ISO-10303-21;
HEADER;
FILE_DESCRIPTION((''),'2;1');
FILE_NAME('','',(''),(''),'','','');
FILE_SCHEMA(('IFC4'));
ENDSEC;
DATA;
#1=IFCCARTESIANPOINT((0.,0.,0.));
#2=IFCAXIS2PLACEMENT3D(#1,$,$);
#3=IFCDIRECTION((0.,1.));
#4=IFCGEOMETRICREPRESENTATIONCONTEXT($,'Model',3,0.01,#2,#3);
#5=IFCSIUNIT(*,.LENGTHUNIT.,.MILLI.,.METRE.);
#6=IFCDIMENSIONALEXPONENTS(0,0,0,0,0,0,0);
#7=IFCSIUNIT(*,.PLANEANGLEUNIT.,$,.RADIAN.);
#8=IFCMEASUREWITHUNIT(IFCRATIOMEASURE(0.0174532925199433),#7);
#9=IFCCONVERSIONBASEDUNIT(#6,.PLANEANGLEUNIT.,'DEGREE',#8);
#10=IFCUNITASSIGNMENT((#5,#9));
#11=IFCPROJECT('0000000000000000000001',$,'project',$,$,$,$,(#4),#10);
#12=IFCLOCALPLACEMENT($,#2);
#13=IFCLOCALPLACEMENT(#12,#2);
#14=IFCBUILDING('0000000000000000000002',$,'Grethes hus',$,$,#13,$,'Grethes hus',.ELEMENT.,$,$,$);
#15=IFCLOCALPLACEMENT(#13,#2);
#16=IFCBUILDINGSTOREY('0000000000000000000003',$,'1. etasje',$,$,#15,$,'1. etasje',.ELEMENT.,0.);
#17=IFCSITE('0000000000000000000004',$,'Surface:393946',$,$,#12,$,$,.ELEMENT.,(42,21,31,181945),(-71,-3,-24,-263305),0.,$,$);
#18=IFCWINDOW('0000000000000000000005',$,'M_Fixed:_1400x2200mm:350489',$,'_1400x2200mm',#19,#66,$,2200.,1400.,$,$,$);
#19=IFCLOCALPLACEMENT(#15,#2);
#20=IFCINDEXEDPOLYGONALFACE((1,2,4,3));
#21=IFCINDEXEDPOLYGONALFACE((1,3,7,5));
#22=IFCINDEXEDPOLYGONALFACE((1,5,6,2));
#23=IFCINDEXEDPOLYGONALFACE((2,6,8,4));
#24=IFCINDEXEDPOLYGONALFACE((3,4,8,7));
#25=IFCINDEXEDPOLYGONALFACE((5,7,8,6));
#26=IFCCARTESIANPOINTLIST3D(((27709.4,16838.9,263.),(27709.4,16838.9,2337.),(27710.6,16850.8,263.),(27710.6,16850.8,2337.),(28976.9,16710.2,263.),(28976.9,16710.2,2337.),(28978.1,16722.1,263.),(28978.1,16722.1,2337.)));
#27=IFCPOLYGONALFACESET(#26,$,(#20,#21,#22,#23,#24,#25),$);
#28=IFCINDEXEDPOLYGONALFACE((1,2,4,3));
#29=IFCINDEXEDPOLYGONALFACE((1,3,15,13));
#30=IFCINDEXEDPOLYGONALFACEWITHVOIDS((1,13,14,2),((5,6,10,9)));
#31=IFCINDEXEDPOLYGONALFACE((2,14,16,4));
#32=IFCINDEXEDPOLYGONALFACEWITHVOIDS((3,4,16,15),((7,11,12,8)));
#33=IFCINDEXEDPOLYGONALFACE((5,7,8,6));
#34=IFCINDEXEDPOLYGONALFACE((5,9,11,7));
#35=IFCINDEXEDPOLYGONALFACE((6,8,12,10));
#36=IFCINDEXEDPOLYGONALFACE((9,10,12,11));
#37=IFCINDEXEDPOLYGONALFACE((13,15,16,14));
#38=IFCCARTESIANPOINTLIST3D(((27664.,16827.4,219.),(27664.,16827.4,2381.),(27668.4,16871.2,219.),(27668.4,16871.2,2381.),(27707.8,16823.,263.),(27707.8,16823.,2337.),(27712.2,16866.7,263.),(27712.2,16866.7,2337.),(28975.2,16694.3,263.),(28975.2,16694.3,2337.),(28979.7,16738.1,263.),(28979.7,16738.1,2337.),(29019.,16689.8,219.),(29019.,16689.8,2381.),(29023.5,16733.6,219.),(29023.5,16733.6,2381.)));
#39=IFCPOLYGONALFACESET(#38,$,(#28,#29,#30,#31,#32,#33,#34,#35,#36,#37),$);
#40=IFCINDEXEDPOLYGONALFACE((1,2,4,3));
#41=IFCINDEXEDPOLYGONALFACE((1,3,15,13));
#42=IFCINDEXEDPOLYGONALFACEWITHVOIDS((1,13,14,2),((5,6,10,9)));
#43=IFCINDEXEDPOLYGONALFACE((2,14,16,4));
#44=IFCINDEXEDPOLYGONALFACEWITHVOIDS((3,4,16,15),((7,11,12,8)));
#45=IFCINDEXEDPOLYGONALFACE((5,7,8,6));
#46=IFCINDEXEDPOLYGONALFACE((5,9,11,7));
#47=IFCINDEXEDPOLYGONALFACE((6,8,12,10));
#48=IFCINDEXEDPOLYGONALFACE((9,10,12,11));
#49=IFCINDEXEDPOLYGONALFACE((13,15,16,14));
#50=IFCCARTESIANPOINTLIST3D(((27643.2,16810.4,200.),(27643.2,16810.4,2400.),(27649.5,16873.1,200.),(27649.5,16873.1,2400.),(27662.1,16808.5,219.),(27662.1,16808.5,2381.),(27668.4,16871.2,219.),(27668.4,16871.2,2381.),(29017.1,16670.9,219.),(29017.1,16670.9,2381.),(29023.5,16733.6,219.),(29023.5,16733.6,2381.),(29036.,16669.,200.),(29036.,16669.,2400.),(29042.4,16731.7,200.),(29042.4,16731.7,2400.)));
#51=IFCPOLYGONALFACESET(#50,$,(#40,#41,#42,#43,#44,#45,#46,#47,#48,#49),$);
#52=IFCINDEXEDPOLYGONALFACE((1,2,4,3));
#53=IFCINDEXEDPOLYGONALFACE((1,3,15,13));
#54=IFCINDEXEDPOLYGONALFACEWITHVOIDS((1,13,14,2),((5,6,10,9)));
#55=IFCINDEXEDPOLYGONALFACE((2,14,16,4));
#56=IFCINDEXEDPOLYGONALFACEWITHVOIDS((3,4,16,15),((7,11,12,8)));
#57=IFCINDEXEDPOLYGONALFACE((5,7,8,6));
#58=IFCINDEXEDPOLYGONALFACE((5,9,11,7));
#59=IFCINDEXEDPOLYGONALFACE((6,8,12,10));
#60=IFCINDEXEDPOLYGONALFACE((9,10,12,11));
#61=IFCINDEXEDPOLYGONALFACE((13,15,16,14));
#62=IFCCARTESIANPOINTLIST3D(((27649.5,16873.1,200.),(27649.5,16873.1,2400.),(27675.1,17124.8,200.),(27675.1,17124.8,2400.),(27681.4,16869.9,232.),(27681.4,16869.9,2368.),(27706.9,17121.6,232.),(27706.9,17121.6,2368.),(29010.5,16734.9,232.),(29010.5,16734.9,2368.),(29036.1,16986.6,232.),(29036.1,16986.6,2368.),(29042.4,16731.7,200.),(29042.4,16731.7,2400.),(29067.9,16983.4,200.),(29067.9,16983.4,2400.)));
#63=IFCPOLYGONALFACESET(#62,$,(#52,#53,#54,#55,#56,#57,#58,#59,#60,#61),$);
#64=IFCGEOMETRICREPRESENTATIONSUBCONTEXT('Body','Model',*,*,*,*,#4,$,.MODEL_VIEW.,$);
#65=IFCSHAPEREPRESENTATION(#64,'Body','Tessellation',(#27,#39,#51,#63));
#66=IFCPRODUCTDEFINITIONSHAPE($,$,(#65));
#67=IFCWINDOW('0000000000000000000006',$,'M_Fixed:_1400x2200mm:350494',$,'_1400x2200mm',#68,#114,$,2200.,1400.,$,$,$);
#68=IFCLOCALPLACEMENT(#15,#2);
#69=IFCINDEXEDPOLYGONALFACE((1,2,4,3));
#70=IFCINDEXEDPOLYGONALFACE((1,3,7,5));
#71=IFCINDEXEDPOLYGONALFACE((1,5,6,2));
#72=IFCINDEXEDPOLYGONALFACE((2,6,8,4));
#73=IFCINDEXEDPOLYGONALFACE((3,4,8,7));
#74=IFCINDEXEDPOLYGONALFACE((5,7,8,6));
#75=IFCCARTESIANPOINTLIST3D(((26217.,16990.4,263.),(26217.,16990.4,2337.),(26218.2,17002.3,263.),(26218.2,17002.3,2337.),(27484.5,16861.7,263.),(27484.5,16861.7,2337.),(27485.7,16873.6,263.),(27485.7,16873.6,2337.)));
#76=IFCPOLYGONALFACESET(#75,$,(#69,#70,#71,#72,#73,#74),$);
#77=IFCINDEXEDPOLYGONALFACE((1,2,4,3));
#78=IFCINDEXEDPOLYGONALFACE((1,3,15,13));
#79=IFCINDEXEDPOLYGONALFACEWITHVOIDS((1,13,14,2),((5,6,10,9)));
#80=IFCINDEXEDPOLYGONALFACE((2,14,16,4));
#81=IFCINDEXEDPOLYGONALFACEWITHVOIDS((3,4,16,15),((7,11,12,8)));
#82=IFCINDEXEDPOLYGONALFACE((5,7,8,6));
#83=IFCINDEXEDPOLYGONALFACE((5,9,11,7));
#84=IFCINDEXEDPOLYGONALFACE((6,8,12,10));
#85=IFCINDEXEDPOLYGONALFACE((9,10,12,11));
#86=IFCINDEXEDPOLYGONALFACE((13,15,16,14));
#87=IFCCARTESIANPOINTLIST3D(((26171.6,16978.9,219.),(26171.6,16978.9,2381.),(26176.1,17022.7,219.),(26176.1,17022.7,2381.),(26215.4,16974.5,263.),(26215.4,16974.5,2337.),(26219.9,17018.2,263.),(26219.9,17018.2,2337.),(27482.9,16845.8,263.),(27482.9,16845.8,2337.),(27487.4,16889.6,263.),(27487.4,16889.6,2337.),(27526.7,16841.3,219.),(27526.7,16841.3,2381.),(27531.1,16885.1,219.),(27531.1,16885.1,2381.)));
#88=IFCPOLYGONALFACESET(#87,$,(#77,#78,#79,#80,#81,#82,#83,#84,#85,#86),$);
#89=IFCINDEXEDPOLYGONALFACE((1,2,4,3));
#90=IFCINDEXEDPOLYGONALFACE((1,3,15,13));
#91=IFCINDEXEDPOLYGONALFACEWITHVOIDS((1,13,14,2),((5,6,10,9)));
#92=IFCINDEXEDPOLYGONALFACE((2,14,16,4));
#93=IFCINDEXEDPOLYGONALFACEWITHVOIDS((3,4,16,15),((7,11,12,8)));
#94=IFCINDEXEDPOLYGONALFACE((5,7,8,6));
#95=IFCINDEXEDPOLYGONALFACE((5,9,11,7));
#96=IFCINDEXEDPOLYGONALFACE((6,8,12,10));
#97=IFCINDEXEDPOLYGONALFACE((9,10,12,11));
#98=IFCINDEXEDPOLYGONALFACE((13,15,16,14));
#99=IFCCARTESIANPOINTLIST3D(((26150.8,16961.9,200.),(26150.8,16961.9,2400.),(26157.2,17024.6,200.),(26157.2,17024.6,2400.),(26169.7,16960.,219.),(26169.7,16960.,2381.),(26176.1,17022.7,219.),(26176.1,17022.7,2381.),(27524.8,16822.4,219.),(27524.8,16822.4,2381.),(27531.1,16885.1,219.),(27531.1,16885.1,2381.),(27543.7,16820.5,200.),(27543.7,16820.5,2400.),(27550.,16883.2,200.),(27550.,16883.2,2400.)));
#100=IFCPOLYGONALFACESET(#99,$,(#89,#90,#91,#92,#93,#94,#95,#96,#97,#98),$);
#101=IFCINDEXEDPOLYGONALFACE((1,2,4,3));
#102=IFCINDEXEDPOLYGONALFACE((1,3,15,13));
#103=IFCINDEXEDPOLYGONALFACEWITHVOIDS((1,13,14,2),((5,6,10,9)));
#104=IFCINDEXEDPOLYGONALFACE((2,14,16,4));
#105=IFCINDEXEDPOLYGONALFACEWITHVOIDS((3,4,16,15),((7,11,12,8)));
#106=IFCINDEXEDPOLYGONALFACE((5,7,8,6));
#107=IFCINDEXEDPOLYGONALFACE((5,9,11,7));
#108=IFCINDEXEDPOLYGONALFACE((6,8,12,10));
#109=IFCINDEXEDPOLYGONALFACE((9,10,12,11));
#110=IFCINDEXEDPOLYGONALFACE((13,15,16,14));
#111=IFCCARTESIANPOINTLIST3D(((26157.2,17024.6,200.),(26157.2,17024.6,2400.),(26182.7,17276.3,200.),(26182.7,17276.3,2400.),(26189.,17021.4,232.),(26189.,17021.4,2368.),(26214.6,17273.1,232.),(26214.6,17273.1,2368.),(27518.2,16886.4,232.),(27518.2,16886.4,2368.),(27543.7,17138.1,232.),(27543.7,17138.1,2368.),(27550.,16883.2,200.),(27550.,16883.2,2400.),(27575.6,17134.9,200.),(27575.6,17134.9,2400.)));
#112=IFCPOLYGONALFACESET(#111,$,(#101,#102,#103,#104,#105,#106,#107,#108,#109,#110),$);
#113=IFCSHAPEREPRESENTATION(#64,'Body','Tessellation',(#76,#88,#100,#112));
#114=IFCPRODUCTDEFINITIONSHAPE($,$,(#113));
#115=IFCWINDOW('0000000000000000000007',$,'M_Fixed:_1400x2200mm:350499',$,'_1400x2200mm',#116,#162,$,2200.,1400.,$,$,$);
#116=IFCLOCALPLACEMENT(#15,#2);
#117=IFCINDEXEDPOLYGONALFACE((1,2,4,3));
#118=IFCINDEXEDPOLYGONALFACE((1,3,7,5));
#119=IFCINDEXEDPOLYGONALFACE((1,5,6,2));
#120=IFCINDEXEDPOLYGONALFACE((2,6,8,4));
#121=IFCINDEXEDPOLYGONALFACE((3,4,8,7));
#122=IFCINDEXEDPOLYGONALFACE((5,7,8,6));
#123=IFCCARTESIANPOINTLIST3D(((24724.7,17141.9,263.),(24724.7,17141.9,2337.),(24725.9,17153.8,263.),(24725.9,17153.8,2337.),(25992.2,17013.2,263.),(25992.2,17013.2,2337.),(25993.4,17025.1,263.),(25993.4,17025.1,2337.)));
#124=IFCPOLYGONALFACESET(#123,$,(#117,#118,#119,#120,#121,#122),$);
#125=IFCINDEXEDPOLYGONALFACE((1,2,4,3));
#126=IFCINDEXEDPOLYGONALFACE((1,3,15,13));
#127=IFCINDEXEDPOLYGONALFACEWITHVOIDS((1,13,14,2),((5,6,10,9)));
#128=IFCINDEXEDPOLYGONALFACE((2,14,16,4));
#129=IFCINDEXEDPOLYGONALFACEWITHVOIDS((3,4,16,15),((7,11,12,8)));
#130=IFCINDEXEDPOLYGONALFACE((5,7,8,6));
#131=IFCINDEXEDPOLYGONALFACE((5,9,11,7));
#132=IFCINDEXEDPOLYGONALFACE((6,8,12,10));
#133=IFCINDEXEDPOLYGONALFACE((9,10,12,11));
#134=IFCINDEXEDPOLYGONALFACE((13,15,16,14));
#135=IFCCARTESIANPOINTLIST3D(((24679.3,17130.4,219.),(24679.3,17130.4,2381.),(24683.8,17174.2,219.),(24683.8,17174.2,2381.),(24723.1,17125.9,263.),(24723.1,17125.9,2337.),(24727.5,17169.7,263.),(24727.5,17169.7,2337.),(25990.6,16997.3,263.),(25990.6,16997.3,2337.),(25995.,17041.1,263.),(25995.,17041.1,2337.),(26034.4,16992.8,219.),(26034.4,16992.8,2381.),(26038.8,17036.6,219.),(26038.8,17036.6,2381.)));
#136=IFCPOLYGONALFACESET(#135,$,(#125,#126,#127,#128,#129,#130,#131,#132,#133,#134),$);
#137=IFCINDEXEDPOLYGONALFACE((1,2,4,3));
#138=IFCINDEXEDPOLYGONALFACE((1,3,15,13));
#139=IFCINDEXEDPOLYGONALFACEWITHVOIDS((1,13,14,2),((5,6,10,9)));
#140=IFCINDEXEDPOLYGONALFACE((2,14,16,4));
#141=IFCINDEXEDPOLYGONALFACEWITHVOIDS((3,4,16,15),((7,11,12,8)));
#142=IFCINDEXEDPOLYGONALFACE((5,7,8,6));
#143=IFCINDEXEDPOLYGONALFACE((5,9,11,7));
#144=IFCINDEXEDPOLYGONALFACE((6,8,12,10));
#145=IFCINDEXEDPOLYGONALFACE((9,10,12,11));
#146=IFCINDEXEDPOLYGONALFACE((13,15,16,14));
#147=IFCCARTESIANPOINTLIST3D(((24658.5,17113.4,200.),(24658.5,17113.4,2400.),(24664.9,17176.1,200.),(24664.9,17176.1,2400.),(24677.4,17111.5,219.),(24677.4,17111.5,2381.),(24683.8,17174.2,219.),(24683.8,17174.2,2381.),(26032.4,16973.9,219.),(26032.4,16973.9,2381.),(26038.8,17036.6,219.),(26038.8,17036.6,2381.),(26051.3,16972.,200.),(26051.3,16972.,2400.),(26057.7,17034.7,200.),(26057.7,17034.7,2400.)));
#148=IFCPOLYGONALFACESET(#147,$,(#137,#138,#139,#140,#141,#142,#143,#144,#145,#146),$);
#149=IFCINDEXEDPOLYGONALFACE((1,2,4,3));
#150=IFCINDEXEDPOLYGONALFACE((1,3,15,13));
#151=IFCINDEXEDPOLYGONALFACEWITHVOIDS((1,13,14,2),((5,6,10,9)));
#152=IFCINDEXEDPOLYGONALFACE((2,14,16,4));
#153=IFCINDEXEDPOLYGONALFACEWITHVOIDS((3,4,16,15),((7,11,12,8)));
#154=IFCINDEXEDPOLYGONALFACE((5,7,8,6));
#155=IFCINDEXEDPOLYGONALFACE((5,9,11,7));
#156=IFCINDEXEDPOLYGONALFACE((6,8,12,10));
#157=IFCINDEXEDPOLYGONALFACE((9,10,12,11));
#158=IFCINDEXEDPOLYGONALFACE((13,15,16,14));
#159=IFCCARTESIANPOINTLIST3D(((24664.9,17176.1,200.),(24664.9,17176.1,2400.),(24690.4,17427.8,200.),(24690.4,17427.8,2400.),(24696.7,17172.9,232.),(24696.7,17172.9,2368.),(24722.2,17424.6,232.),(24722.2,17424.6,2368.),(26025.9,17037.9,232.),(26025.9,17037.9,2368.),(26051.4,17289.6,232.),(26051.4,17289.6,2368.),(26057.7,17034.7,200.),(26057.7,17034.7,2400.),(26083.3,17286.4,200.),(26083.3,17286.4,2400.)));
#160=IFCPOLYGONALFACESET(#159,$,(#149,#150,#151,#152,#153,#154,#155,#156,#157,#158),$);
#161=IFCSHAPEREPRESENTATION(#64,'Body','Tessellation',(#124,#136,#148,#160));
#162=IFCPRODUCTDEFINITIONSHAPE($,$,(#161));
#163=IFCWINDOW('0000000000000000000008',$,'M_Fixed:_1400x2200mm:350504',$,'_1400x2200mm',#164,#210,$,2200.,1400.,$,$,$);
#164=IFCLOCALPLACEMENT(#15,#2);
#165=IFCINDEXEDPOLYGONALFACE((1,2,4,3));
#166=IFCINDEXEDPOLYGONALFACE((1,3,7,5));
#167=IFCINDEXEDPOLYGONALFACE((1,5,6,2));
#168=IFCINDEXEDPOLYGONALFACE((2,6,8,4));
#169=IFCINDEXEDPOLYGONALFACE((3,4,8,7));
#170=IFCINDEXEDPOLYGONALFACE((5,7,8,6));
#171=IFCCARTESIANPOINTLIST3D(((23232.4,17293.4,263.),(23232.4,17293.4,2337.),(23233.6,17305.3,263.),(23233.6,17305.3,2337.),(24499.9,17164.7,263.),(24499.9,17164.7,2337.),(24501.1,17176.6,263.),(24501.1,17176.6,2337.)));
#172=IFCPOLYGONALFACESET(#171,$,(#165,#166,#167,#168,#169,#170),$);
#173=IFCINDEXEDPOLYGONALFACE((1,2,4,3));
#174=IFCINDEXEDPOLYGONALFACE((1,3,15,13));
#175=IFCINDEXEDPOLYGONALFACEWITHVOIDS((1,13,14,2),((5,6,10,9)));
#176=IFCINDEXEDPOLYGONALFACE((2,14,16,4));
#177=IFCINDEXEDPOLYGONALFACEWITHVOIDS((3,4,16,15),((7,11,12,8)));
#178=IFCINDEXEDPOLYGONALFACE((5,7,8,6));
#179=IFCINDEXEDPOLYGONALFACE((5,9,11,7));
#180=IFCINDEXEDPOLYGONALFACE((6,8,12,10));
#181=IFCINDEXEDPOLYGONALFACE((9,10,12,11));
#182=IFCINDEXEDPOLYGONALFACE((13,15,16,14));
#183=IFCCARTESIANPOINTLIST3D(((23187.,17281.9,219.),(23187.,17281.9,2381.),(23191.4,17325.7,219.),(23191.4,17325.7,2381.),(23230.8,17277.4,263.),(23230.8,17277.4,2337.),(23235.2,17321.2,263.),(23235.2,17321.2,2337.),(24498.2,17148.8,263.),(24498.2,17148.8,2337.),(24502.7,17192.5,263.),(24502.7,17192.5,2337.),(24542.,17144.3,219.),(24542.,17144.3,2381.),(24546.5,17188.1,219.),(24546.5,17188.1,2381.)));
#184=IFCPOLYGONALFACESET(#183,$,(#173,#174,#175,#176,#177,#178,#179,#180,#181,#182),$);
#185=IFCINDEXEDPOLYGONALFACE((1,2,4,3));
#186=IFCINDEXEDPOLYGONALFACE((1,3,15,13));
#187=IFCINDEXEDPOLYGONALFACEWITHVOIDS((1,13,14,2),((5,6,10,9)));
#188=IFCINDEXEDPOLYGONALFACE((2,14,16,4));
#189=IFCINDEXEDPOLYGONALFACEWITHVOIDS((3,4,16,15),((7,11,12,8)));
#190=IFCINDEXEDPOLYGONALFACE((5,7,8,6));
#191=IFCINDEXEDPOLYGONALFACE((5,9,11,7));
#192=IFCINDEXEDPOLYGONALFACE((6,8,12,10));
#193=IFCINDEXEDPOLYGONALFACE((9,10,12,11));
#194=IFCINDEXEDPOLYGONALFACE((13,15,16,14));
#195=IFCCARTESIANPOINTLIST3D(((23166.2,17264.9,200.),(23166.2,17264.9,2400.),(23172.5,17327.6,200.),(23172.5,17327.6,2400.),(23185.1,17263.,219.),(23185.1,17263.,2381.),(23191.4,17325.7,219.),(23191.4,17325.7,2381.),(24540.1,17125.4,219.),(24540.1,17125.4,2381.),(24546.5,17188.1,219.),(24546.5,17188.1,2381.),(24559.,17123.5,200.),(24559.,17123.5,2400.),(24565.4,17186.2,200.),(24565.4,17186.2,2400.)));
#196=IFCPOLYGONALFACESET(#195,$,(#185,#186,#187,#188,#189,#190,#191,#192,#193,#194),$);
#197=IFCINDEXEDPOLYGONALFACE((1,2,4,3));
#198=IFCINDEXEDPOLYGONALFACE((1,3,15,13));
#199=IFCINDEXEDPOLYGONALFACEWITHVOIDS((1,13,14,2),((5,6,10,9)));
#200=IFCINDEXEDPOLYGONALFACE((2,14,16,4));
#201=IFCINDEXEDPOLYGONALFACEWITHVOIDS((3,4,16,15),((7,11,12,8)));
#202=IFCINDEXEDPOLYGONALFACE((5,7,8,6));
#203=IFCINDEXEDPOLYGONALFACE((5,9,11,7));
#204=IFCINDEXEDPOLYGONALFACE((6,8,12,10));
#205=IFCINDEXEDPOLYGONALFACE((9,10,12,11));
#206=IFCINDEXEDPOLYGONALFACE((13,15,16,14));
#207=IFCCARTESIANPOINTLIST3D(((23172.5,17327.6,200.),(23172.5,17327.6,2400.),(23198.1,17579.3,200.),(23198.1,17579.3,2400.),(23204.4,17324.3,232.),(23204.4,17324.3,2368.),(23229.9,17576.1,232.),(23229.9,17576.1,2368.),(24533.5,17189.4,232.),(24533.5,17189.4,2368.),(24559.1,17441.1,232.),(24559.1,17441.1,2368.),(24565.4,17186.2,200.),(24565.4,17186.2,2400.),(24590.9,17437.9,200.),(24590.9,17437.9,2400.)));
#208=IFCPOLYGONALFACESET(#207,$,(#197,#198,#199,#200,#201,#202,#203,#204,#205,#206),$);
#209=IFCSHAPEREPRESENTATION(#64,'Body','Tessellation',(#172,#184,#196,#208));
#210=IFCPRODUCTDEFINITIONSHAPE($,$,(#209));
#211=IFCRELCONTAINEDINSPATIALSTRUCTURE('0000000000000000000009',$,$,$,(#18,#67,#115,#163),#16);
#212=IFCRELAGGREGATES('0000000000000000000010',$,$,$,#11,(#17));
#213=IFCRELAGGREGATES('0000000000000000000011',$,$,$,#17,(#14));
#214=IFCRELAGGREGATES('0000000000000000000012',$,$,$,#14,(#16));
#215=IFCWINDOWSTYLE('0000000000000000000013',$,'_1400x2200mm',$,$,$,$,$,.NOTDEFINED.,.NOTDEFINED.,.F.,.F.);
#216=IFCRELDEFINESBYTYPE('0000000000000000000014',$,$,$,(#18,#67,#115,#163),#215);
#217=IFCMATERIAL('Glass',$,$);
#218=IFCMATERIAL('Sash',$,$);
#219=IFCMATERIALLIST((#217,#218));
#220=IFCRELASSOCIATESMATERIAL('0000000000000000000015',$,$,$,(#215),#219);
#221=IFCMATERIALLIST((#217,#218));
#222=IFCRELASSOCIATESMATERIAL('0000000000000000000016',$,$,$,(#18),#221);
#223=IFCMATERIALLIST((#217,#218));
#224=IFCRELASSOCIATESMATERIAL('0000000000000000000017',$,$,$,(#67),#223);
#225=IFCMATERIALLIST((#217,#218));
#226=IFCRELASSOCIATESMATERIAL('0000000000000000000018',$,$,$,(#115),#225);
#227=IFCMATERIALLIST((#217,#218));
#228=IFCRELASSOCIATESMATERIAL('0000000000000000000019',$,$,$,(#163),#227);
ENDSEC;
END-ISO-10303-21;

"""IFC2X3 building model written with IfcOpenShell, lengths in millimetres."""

from ifc_helpers import new_model, entity, si_unit, converted_unit, direction, frame, frame_2d, origin, place, context, subcontext, project, spatial, polyline, rectangle, outline, extrude, source, transform, mapped, material, material_list, type_object, type_shapes, element, save


model = new_model("IFC2X3")

# Units and contexts
model_context = context("Model", 3, precision=0.01, world=origin(), true_north=direction((0.0, 1.0)))
body_context = subcontext(model_context, "Body", "Model", "MODEL_VIEW")
ifc_project = project(units=[si_unit("LENGTHUNIT", "METRE", prefix="MILLI"), converted_unit("PLANEANGLEUNIT", "DEGREE", entity("IfcRatioMeasure", 0.0174532925199433), si_unit("PLANEANGLEUNIT", "RADIAN"), dimensions=[0, 0, 0, 0, 0, 0, 0])], contexts=[model_context])

# Site, building, storey
site_placement = place(None, origin())
site = spatial("IfcSite", under=ifc_project, at=site_placement, Name="Surface:393946", CompositionType="ELEMENT", RefLatitude=(42, 21, 31, 181945), RefLongitude=(-71, -3, -24, -263305), RefElevation=0.0)
building_placement = place(site_placement, origin())
building = spatial("IfcBuilding", under=site, at=building_placement, Name="Grethes hus", LongName="Grethes hus", CompositionType="ELEMENT")
storey_placement = place(building_placement, origin())
storey = spatial("IfcBuildingStorey", under=building, at=storey_placement, Name="1. etasje", LongName="1. etasje", CompositionType="ELEMENT", Elevation=0.0)

# Windows
ifc_material_1 = material(Name="Glass")
ifc_material_2 = material(Name="Sash")
ifc_material_list_1 = material_list([ifc_material_1, ifc_material_2])
ifc_material_list_2 = material_list([ifc_material_1, ifc_material_2])
window_style_1 = type_object("IfcWindowStyle", Name="_1400x2200mm", ConstructionType="NOTDEFINED", OperationType="NOTDEFINED", ParameterTakesPrecedence=False, Sizeable=False, material=ifc_material_list_2)
shared_shape_1 = source(origin(), body_context, "Body", "SweptSolid", [
    extrude(rectangle(XDim=12.0, YDim=1274.0, at=frame_2d((0.0, 0.0), x_axis=(1.0, 0.0))), frame((700.0, 275.0, 63.0), z_axis=(0.0, 0.0, 1.0), x_axis=(0.0, -1.0, 0.0)), (0.0, 0.0, 1.0), 2074.0),
    extrude(outline(polyline([(-681.0, -1081.0), (681.0, -1081.0), (681.0, 1081.0), (-681.0, 1081.0), (-681.0, -1081.0)]), holes=[polyline([(-637.0, -1037.0), (-637.0, 1037.0), (637.0, 1037.0), (637.0, -1037.0), (-637.0, -1037.0)])]), frame((700.0, 253.0, 1100.0), z_axis=(0.0, 1.0, 0.0), x_axis=(1.0, 0.0, 0.0)), (0.0, 0.0, 1.0), 44.0),
    extrude(outline(polyline([(-700.0, -1100.0), (700.0, -1100.0), (700.0, 1100.0), (-700.0, 1100.0), (-700.0, -1100.0)]), holes=[polyline([(-681.0, -1081.0), (-681.0, 1081.0), (681.0, 1081.0), (681.0, -1081.0), (-681.0, -1081.0)])]), frame((700.0, 253.0, 1100.0), z_axis=(0.0, 1.0, 0.0), x_axis=(1.0, 0.0, 0.0)), (0.0, 0.0, 1.0), 63.0),
    extrude(outline(polyline([(-700.0, -1100.0), (700.0, -1100.0), (700.0, 1100.0), (-700.0, 1100.0), (-700.0, -1100.0)]), holes=[polyline([(-668.0, -1068.0), (-668.0, 1068.0), (668.0, 1068.0), (668.0, -1068.0), (-668.0, -1068.0)])]), frame((700.0, 0.0, 1100.0), z_axis=(0.0, 1.0, 0.0), x_axis=(1.0, 0.0, 0.0)), (0.0, 0.0, 1.0), 253.0),
])
type_shapes(window_style_1, [shared_shape_1])
placement_1 = place(storey_placement, frame((35426.2, 16179.1, 0.0), z_axis=(0.0, 0.0, 1.0), x_axis=(-0.994887, 0.100996, 0.0)))
placement_2 = place(placement_1, frame((6407.0, -158.0, 200.0)))
window_1_placement = place(placement_2, origin())
element("IfcWindow", 1, at=window_1_placement, inside=storey, type_object=window_style_1, material=ifc_material_list_1, Name="M_Fixed:_1400x2200mm:350489", ObjectType="_1400x2200mm", OverallHeight=2200.0, OverallWidth=1400.0, context=body_context, shape_type="MappedRepresentation", body=[
    mapped(shared_shape_1, transform((0.0, 0.0, 0.0), scale=1.0)),
])
ifc_material_list_3 = material_list([ifc_material_1, ifc_material_2])
placement_3 = place(placement_1, frame((7907.0, -158.0, 200.0)))
window_2_placement = place(placement_3, origin())
element("IfcWindow", 2, at=window_2_placement, inside=storey, type_object=window_style_1, material=ifc_material_list_3, Name="M_Fixed:_1400x2200mm:350494", ObjectType="_1400x2200mm", OverallHeight=2200.0, OverallWidth=1400.0, context=body_context, shape_type="MappedRepresentation", body=[
    mapped(shared_shape_1, transform((0.0, 0.0, 0.0), scale=1.0)),
])
ifc_material_list_4 = material_list([ifc_material_1, ifc_material_2])
placement_4 = place(placement_1, frame((9407.0, -158.0, 200.0)))
window_3_placement = place(placement_4, origin())
element("IfcWindow", 3, at=window_3_placement, inside=storey, type_object=window_style_1, material=ifc_material_list_4, Name="M_Fixed:_1400x2200mm:350499", ObjectType="_1400x2200mm", OverallHeight=2200.0, OverallWidth=1400.0, context=body_context, shape_type="MappedRepresentation", body=[
    mapped(shared_shape_1, transform((0.0, 0.0, 0.0), scale=1.0)),
])
ifc_material_list_5 = material_list([ifc_material_1, ifc_material_2])
placement_5 = place(placement_1, frame((10907.0, -158.0, 200.0)))
window_4_placement = place(placement_5, origin())
element("IfcWindow", 4, at=window_4_placement, inside=storey, type_object=window_style_1, material=ifc_material_list_5, Name="M_Fixed:_1400x2200mm:350504", ObjectType="_1400x2200mm", OverallHeight=2200.0, OverallWidth=1400.0, context=body_context, shape_type="MappedRepresentation", body=[
    mapped(shared_shape_1, transform((0.0, 0.0, 0.0), scale=1.0)),
])

save(model, "model.ifc")
